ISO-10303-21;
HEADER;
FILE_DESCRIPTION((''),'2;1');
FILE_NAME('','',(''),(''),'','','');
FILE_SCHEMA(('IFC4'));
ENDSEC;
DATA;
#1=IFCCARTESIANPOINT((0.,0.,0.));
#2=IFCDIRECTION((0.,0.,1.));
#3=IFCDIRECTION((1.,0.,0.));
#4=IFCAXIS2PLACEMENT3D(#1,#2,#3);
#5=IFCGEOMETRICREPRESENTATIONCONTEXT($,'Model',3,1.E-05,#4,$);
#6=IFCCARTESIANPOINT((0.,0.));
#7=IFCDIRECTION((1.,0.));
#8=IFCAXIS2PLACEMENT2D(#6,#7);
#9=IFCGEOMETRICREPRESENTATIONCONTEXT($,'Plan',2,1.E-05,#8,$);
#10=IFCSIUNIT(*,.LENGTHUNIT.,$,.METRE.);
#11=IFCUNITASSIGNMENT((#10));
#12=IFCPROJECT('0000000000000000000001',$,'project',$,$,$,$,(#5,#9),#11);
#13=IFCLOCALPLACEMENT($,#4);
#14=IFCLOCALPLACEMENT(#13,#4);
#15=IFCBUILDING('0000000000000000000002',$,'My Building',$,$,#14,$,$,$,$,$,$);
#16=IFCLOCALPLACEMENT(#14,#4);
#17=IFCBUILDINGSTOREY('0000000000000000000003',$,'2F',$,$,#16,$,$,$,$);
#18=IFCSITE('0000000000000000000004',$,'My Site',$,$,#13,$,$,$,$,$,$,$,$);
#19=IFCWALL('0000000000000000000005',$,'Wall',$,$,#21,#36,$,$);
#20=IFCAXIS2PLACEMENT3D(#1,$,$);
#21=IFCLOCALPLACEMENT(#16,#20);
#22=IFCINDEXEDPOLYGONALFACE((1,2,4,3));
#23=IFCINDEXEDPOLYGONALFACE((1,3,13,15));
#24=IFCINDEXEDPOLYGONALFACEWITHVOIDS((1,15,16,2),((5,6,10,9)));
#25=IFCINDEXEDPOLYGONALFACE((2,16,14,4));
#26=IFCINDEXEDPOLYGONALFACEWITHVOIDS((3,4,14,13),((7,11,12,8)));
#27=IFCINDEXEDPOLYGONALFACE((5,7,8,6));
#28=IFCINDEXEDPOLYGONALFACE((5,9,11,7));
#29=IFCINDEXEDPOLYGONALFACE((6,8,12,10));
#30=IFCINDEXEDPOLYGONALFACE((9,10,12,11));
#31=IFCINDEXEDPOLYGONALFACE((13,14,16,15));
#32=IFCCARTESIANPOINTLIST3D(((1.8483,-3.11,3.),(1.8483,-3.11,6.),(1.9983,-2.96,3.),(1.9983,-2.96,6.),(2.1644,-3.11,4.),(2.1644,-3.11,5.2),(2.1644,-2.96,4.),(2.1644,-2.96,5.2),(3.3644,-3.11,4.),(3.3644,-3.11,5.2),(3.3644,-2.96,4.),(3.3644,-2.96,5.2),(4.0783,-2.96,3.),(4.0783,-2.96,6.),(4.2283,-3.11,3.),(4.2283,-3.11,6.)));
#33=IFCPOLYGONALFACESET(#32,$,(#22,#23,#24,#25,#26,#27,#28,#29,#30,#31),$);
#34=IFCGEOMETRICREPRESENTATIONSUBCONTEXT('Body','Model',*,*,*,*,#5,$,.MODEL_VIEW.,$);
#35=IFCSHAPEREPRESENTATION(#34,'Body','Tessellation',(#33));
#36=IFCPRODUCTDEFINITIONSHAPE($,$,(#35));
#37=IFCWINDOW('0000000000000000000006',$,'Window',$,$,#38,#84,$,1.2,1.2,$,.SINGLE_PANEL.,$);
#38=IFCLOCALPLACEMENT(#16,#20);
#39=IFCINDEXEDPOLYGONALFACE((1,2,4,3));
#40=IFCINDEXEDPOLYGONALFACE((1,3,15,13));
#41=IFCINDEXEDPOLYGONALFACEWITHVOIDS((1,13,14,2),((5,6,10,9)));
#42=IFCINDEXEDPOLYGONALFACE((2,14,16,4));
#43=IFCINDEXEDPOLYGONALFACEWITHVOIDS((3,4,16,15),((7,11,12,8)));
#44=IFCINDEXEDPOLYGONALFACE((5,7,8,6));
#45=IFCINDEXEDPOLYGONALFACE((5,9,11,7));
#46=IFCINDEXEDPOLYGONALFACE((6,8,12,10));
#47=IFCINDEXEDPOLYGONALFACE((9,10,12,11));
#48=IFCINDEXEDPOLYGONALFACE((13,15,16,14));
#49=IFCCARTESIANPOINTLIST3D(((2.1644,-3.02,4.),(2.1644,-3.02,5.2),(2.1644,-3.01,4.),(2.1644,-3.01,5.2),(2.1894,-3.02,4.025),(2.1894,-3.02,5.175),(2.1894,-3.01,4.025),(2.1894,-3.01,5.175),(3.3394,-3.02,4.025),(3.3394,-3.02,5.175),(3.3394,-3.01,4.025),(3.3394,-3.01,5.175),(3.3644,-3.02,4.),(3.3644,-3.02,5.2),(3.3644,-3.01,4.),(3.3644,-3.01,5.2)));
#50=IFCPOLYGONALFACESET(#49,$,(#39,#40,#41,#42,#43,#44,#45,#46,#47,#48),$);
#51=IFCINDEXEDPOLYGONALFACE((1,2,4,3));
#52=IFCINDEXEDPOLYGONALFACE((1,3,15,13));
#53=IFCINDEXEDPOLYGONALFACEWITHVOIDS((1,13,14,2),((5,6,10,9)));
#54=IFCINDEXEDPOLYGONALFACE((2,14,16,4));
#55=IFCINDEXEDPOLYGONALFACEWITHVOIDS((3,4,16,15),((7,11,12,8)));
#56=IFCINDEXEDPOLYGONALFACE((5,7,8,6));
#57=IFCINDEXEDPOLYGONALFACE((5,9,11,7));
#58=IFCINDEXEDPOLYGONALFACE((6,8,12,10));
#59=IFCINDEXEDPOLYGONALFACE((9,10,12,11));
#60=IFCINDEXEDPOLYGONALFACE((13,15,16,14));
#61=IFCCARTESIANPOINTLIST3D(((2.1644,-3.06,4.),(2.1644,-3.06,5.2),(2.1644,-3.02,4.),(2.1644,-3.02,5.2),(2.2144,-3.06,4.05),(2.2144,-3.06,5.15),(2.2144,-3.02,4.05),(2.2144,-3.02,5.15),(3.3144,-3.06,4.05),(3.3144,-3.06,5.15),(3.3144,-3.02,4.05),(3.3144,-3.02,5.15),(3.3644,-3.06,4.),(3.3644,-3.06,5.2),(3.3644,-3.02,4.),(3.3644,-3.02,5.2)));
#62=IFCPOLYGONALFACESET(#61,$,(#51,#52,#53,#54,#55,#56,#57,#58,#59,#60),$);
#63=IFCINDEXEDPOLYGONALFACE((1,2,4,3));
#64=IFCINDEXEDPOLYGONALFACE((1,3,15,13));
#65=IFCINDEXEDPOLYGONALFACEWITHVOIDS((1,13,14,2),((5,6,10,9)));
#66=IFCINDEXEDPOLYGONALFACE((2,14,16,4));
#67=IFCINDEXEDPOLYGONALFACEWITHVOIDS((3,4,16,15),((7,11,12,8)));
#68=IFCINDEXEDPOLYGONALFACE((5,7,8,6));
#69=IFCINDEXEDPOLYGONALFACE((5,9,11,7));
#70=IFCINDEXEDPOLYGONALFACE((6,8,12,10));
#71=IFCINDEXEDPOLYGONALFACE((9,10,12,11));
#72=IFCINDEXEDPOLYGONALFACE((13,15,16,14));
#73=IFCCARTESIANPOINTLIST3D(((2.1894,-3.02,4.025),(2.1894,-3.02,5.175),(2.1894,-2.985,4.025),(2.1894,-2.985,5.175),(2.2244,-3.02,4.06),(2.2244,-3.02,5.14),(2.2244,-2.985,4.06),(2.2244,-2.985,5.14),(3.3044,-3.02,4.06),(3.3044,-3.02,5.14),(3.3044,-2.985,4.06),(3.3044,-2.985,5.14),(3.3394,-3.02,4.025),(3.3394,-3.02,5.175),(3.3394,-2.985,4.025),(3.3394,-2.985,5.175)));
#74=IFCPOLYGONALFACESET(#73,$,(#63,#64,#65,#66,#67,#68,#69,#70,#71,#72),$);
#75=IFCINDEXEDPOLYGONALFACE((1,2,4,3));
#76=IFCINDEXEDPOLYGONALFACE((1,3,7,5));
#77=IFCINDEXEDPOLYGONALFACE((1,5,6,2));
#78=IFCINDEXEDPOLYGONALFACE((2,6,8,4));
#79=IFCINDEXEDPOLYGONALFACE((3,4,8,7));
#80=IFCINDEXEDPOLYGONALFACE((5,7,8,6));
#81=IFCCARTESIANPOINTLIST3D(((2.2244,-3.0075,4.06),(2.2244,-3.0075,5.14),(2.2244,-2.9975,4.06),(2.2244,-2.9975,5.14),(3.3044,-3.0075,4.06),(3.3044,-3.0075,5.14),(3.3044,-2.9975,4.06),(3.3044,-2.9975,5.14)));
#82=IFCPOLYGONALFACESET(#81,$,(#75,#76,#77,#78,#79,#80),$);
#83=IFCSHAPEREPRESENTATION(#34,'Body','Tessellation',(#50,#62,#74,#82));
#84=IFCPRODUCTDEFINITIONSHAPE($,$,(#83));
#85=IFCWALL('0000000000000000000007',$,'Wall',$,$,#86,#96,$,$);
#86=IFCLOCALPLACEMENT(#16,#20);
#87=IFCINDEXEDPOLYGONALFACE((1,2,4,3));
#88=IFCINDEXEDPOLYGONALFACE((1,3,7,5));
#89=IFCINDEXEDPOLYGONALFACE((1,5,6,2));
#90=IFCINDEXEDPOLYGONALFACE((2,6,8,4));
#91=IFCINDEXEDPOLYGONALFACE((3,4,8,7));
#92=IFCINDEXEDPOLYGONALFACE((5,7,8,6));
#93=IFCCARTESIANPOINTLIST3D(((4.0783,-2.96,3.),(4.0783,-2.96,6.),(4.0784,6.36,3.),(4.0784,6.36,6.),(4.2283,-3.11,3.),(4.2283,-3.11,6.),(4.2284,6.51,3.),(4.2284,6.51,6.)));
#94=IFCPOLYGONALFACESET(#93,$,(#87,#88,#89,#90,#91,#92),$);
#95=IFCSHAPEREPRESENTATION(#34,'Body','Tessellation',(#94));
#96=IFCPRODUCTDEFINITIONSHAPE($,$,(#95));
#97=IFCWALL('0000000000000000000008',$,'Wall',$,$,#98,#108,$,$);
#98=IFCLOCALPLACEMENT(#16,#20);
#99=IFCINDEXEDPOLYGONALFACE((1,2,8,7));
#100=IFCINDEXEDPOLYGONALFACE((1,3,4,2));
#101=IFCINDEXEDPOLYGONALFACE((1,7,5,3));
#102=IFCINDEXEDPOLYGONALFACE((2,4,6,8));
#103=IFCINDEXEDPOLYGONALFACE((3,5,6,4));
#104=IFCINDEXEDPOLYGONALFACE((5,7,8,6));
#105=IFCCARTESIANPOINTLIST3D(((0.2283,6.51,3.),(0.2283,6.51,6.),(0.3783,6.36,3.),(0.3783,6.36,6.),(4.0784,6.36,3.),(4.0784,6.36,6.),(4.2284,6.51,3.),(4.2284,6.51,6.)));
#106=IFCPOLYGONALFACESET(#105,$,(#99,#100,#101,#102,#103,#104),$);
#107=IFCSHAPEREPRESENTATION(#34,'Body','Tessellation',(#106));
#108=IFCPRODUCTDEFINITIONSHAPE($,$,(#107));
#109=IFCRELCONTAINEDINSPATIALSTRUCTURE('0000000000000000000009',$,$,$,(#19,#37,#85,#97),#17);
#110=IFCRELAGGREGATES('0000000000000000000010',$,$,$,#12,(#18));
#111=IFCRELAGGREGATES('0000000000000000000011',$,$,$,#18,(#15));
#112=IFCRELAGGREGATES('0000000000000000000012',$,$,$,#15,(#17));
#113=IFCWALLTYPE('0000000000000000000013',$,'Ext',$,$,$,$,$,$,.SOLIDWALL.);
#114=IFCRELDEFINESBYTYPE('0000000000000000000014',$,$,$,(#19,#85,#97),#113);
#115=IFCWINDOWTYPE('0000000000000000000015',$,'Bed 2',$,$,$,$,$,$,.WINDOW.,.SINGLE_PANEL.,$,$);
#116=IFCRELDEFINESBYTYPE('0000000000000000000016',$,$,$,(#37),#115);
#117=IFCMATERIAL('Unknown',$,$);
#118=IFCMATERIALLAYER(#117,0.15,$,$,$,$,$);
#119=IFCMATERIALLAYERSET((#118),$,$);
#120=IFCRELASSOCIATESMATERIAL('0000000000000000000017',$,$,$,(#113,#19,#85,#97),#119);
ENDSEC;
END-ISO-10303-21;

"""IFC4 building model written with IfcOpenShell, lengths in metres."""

from ifc_helpers import new_model, entity, si_unit, frame, origin_with_axes, origin_2d_with_axis, place, context, subcontext, project, spatial, line, indexed_curve, outline, extrude, shape, source, transform, mapped, material, layer, layer_set, layer_usage, type_object, type_shapes, element, fill, save


model = new_model("IFC4")

# Units and contexts
model_context = context("Model", 3, precision=1e-05, world=origin_with_axes())
plan_context = context("Plan", 2, precision=1e-05, world=origin_2d_with_axis())
body_context_1 = subcontext(model_context, "Body", "Model", "MODEL_VIEW")
body_context_2 = subcontext(plan_context, "Body", "Plan", "PLAN_VIEW")
ifc_project = project(units=[si_unit("LENGTHUNIT", "METRE")], contexts=[model_context, plan_context])

# Site, building, storey
site_placement = place(None, origin_with_axes())
site = spatial("IfcSite", under=ifc_project, at=site_placement, Name="My Site")
building_placement = place(site_placement, origin_with_axes())
building = spatial("IfcBuilding", under=site, at=building_placement, Name="My Building")
storey_placement = place(building_placement, origin_with_axes())
storey = spatial("IfcBuildingStorey", under=building, at=storey_placement, Name="2F")

# Shared definitions
ifc_material = material(Name="Unknown")
ifc_layer_1 = layer(ifc_material, 0.15)
ifc_layer_set_1 = layer_set([ifc_layer_1])
wall_type_1 = type_object("IfcWallType", Name="Ext", PredefinedType="SOLIDWALL", material=ifc_layer_set_1)

# Wall, opening, window
ifc_layer_usage_1 = layer_usage(ifc_layer_set_1, "AXIS2", "POSITIVE", 0.0)
wall_1_placement = place(storey_placement, frame((1.8483, -3.11, 3.0), z_axis=(0.0, 0.0, 1.0), x_axis=(1.0, 0.0, 0.0)))
wall_1 = element("IfcWall", 1, at=wall_1_placement, inside=storey, type_object=wall_type_1, material=ifc_layer_usage_1, Name="Wall", context=body_context_1, shape_type="SweptSolid", body=[
    extrude(outline(indexed_curve([(0.0, 0.0), (0.15, 0.15), (2.23, 0.15), (2.38, 0.0)], segments=[line(1, 2, 3, 4, 1)])), origin_with_axes(), (0.0, 0.0, 1.0), 3.0),
])
shared_shape_1 = source(origin_with_axes(), body_context_1, "Body", "SweptSolid", [
    extrude(outline(indexed_curve([(0.0, 0.0), (1.2, 0.0), (1.2, 1.2), (0.0, 1.2)], segments=[line(1, 2, 3, 4, 1)])), frame((0.0, -0.6, 0.0), z_axis=(0.0, -1.0, 0.0), x_axis=(1.0, 0.0, 0.0)), (0.0, 0.0, -1.0), 1.2),
])
opening_1_placement = place(wall_1_placement, frame((0.316, 0.0, 1.0), z_axis=(0.0, 0.0, 1.0), x_axis=(1.0, 0.0, 0.0)))
opening_1 = element("IfcOpeningElement", 2, at=opening_1_placement, cuts=wall_1, PredefinedType="OPENING", context=body_context_1, shape_type="MappedRepresentation", body=[
    mapped(shared_shape_1, transform((0.0, 0.0, 0.0), x_axis=(1.0, 0.0, 0.0), y_axis=(0.0, 1.0, 0.0), z_axis=(0.0, 0.0, 1.0), scale=1.0)),
])
window_type_1 = type_object("IfcWindowType", Name="Bed 2", PartitioningType="SINGLE_PANEL", PredefinedType="WINDOW")
shared_shape_2 = source(origin_with_axes(), body_context_1, "Body", "SweptSolid", [
    extrude(outline(indexed_curve([(0.0, 0.0), (1.2, 0.0), (1.2, 1.2), (0.0, 1.2)], segments=[line(1, 2, 3, 4, 1)]), holes=[indexed_curve([(0.025, 0.025), (1.175, 0.025), (1.175, 1.175), (0.025, 1.175)], segments=[line(1, 2, 3, 4, 1)])]), frame((0.0, 0.09, 0.0), z_axis=(0.0, -1.0, 0.0), x_axis=(1.0, 0.0, 0.0)), (0.0, 0.0, -1.0), 0.01),
    extrude(outline(indexed_curve([(0.0, 0.0), (1.2, 0.0), (1.2, 1.2), (0.0, 1.2)], segments=[line(1, 2, 3, 4, 1)]), holes=[indexed_curve([(0.05, 0.05), (1.15, 0.05), (1.15, 1.15), (0.05, 1.15)], segments=[line(1, 2, 3, 4, 1)])]), frame((0.0, 0.05, 0.0), z_axis=(0.0, -1.0, 0.0), x_axis=(1.0, 0.0, 0.0)), (0.0, 0.0, -1.0), 0.04),
    extrude(outline(indexed_curve([(0.0, 0.0), (1.15, 0.0), (1.15, 1.15), (0.0, 1.15)], segments=[line(1, 2, 3, 4, 1)]), holes=[indexed_curve([(0.035, 0.035), (1.115, 0.035), (1.115, 1.115), (0.035, 1.115)], segments=[line(1, 2, 3, 4, 1)])]), frame((0.025, 0.09, 0.025), z_axis=(0.0, -1.0, 0.0), x_axis=(1.0, 0.0, 0.0)), (0.0, 0.0, -1.0), 0.035),
    extrude(outline(indexed_curve([(0.035, 0.035), (1.115, 0.035), (1.115, 1.115), (0.035, 1.115)], segments=[line(1, 2, 3, 4, 1)])), frame((0.025, 0.1025, 0.025), z_axis=(0.0, -1.0, 0.0), x_axis=(1.0, 0.0, 0.0)), (0.0, 0.0, -1.0), 0.01),
])
shared_shape_3 = source(origin_with_axes(), body_context_2, "Body", "Curve2D", [
    entity("IfcIndexedPolyCurve", entity("IfcCartesianPointList2D", [[0.05, 0.05], [1.15, 0.05]])),
    entity("IfcIndexedPolyCurve", entity("IfcCartesianPointList2D", [[0.0, 0.1], [0.025, 0.1], [0.025, 0.09], [0.05, 0.09], [0.05, 0.05], [0.0, 0.05]]), [entity("IfcLineIndex", [1, 2, 3, 4, 5, 6, 1])]),
    entity("IfcIndexedPolyCurve", entity("IfcCartesianPointList2D", [[1.2, 0.1], [1.175, 0.1], [1.175, 0.09], [1.15, 0.09], [1.15, 0.05], [1.2, 0.05]]), [entity("IfcLineIndex", [1, 2, 3, 4, 5, 6, 1])]),
    entity("IfcIndexedPolyCurve", entity("IfcCartesianPointList2D", [[0.025, 0.09], [0.06, 0.09], [0.06, 0.125], [0.025, 0.125]]), [entity("IfcLineIndex", [1, 2, 3, 4, 1])]),
    entity("IfcIndexedPolyCurve", entity("IfcCartesianPointList2D", [[1.175, 0.09], [1.14, 0.09], [1.14, 0.125], [1.175, 0.125]]), [entity("IfcLineIndex", [1, 2, 3, 4, 1])]),
    entity("IfcIndexedPolyCurve", entity("IfcCartesianPointList2D", [[0.06, 0.09], [1.14, 0.09]])),
    entity("IfcIndexedPolyCurve", entity("IfcCartesianPointList2D", [[0.06, 0.125], [1.14, 0.125]])),
    entity("IfcIndexedPolyCurve", entity("IfcCartesianPointList2D", [[0.06, 0.1075], [1.14, 0.1075]])),
])
type_shapes(window_type_1, [shared_shape_2, shared_shape_3])
window_1_placement = place(opening_1_placement, frame((0.0, 0.0, 0.0), z_axis=(0.0, 0.0, 1.0), x_axis=(1.0, 0.0, 0.0)))
window_1 = element("IfcWindow", 3, at=window_1_placement, inside=storey, type_object=window_type_1, Name="Window", OverallHeight=1.2, OverallWidth=1.2, PartitioningType="SINGLE_PANEL", shapes=[
    shape(body_context_1, "Body", "MappedRepresentation", [mapped(shared_shape_2, transform((0.0, 0.0, 0.0), x_axis=(1.0, 0.0, 0.0), y_axis=(0.0, 1.0, 0.0), z_axis=(0.0, 0.0, 1.0), scale=1.0))]),
    shape(body_context_2, "Body", "MappedRepresentation", [mapped(shared_shape_3, transform((0.0, 0.0, 0.0), x_axis=(1.0, 0.0, 0.0), y_axis=(0.0, 1.0, 0.0), z_axis=(0.0, 0.0, 1.0), scale=1.0))]),
])
fill(opening_1, window_1)

# Walls
ifc_layer_usage_2 = layer_usage(ifc_layer_set_1, "AXIS2", "POSITIVE", 0.0)
wall_2_placement = place(storey_placement, frame((4.2283, -3.11, 3.0), z_axis=(0.0, 0.0, 1.0), x_axis=(0.0, 1.0, 0.0)))
element("IfcWall", 4, at=wall_2_placement, inside=storey, type_object=wall_type_1, material=ifc_layer_usage_2, Name="Wall", context=body_context_1, shape_type="SweptSolid", body=[
    extrude(outline(indexed_curve([(0.0, 0.0), (0.15, 0.15), (9.47, 0.15), (9.62, 0.0)], segments=[line(1, 2, 3, 4, 1)])), origin_with_axes(), (0.0, 0.0, 1.0), 3.0),
])
ifc_layer_usage_3 = layer_usage(ifc_layer_set_1, "AXIS2", "POSITIVE", 0.0)
wall_3_placement = place(storey_placement, frame((4.2284, 6.51, 3.0), z_axis=(0.0, 0.0, 1.0), x_axis=(-1.0, 0.0, 0.0)))
element("IfcWall", 5, at=wall_3_placement, inside=storey, type_object=wall_type_1, material=ifc_layer_usage_3, Name="Wall", context=body_context_1, shape_type="SweptSolid", body=[
    extrude(outline(indexed_curve([(0.0, 0.0), (0.15, 0.15), (3.85, 0.15), (4.0, 0.0)], segments=[line(1, 2, 3, 4, 1)])), origin_with_axes(), (0.0, 0.0, 1.0), 3.0),
])

save(model, "model.ifc")
